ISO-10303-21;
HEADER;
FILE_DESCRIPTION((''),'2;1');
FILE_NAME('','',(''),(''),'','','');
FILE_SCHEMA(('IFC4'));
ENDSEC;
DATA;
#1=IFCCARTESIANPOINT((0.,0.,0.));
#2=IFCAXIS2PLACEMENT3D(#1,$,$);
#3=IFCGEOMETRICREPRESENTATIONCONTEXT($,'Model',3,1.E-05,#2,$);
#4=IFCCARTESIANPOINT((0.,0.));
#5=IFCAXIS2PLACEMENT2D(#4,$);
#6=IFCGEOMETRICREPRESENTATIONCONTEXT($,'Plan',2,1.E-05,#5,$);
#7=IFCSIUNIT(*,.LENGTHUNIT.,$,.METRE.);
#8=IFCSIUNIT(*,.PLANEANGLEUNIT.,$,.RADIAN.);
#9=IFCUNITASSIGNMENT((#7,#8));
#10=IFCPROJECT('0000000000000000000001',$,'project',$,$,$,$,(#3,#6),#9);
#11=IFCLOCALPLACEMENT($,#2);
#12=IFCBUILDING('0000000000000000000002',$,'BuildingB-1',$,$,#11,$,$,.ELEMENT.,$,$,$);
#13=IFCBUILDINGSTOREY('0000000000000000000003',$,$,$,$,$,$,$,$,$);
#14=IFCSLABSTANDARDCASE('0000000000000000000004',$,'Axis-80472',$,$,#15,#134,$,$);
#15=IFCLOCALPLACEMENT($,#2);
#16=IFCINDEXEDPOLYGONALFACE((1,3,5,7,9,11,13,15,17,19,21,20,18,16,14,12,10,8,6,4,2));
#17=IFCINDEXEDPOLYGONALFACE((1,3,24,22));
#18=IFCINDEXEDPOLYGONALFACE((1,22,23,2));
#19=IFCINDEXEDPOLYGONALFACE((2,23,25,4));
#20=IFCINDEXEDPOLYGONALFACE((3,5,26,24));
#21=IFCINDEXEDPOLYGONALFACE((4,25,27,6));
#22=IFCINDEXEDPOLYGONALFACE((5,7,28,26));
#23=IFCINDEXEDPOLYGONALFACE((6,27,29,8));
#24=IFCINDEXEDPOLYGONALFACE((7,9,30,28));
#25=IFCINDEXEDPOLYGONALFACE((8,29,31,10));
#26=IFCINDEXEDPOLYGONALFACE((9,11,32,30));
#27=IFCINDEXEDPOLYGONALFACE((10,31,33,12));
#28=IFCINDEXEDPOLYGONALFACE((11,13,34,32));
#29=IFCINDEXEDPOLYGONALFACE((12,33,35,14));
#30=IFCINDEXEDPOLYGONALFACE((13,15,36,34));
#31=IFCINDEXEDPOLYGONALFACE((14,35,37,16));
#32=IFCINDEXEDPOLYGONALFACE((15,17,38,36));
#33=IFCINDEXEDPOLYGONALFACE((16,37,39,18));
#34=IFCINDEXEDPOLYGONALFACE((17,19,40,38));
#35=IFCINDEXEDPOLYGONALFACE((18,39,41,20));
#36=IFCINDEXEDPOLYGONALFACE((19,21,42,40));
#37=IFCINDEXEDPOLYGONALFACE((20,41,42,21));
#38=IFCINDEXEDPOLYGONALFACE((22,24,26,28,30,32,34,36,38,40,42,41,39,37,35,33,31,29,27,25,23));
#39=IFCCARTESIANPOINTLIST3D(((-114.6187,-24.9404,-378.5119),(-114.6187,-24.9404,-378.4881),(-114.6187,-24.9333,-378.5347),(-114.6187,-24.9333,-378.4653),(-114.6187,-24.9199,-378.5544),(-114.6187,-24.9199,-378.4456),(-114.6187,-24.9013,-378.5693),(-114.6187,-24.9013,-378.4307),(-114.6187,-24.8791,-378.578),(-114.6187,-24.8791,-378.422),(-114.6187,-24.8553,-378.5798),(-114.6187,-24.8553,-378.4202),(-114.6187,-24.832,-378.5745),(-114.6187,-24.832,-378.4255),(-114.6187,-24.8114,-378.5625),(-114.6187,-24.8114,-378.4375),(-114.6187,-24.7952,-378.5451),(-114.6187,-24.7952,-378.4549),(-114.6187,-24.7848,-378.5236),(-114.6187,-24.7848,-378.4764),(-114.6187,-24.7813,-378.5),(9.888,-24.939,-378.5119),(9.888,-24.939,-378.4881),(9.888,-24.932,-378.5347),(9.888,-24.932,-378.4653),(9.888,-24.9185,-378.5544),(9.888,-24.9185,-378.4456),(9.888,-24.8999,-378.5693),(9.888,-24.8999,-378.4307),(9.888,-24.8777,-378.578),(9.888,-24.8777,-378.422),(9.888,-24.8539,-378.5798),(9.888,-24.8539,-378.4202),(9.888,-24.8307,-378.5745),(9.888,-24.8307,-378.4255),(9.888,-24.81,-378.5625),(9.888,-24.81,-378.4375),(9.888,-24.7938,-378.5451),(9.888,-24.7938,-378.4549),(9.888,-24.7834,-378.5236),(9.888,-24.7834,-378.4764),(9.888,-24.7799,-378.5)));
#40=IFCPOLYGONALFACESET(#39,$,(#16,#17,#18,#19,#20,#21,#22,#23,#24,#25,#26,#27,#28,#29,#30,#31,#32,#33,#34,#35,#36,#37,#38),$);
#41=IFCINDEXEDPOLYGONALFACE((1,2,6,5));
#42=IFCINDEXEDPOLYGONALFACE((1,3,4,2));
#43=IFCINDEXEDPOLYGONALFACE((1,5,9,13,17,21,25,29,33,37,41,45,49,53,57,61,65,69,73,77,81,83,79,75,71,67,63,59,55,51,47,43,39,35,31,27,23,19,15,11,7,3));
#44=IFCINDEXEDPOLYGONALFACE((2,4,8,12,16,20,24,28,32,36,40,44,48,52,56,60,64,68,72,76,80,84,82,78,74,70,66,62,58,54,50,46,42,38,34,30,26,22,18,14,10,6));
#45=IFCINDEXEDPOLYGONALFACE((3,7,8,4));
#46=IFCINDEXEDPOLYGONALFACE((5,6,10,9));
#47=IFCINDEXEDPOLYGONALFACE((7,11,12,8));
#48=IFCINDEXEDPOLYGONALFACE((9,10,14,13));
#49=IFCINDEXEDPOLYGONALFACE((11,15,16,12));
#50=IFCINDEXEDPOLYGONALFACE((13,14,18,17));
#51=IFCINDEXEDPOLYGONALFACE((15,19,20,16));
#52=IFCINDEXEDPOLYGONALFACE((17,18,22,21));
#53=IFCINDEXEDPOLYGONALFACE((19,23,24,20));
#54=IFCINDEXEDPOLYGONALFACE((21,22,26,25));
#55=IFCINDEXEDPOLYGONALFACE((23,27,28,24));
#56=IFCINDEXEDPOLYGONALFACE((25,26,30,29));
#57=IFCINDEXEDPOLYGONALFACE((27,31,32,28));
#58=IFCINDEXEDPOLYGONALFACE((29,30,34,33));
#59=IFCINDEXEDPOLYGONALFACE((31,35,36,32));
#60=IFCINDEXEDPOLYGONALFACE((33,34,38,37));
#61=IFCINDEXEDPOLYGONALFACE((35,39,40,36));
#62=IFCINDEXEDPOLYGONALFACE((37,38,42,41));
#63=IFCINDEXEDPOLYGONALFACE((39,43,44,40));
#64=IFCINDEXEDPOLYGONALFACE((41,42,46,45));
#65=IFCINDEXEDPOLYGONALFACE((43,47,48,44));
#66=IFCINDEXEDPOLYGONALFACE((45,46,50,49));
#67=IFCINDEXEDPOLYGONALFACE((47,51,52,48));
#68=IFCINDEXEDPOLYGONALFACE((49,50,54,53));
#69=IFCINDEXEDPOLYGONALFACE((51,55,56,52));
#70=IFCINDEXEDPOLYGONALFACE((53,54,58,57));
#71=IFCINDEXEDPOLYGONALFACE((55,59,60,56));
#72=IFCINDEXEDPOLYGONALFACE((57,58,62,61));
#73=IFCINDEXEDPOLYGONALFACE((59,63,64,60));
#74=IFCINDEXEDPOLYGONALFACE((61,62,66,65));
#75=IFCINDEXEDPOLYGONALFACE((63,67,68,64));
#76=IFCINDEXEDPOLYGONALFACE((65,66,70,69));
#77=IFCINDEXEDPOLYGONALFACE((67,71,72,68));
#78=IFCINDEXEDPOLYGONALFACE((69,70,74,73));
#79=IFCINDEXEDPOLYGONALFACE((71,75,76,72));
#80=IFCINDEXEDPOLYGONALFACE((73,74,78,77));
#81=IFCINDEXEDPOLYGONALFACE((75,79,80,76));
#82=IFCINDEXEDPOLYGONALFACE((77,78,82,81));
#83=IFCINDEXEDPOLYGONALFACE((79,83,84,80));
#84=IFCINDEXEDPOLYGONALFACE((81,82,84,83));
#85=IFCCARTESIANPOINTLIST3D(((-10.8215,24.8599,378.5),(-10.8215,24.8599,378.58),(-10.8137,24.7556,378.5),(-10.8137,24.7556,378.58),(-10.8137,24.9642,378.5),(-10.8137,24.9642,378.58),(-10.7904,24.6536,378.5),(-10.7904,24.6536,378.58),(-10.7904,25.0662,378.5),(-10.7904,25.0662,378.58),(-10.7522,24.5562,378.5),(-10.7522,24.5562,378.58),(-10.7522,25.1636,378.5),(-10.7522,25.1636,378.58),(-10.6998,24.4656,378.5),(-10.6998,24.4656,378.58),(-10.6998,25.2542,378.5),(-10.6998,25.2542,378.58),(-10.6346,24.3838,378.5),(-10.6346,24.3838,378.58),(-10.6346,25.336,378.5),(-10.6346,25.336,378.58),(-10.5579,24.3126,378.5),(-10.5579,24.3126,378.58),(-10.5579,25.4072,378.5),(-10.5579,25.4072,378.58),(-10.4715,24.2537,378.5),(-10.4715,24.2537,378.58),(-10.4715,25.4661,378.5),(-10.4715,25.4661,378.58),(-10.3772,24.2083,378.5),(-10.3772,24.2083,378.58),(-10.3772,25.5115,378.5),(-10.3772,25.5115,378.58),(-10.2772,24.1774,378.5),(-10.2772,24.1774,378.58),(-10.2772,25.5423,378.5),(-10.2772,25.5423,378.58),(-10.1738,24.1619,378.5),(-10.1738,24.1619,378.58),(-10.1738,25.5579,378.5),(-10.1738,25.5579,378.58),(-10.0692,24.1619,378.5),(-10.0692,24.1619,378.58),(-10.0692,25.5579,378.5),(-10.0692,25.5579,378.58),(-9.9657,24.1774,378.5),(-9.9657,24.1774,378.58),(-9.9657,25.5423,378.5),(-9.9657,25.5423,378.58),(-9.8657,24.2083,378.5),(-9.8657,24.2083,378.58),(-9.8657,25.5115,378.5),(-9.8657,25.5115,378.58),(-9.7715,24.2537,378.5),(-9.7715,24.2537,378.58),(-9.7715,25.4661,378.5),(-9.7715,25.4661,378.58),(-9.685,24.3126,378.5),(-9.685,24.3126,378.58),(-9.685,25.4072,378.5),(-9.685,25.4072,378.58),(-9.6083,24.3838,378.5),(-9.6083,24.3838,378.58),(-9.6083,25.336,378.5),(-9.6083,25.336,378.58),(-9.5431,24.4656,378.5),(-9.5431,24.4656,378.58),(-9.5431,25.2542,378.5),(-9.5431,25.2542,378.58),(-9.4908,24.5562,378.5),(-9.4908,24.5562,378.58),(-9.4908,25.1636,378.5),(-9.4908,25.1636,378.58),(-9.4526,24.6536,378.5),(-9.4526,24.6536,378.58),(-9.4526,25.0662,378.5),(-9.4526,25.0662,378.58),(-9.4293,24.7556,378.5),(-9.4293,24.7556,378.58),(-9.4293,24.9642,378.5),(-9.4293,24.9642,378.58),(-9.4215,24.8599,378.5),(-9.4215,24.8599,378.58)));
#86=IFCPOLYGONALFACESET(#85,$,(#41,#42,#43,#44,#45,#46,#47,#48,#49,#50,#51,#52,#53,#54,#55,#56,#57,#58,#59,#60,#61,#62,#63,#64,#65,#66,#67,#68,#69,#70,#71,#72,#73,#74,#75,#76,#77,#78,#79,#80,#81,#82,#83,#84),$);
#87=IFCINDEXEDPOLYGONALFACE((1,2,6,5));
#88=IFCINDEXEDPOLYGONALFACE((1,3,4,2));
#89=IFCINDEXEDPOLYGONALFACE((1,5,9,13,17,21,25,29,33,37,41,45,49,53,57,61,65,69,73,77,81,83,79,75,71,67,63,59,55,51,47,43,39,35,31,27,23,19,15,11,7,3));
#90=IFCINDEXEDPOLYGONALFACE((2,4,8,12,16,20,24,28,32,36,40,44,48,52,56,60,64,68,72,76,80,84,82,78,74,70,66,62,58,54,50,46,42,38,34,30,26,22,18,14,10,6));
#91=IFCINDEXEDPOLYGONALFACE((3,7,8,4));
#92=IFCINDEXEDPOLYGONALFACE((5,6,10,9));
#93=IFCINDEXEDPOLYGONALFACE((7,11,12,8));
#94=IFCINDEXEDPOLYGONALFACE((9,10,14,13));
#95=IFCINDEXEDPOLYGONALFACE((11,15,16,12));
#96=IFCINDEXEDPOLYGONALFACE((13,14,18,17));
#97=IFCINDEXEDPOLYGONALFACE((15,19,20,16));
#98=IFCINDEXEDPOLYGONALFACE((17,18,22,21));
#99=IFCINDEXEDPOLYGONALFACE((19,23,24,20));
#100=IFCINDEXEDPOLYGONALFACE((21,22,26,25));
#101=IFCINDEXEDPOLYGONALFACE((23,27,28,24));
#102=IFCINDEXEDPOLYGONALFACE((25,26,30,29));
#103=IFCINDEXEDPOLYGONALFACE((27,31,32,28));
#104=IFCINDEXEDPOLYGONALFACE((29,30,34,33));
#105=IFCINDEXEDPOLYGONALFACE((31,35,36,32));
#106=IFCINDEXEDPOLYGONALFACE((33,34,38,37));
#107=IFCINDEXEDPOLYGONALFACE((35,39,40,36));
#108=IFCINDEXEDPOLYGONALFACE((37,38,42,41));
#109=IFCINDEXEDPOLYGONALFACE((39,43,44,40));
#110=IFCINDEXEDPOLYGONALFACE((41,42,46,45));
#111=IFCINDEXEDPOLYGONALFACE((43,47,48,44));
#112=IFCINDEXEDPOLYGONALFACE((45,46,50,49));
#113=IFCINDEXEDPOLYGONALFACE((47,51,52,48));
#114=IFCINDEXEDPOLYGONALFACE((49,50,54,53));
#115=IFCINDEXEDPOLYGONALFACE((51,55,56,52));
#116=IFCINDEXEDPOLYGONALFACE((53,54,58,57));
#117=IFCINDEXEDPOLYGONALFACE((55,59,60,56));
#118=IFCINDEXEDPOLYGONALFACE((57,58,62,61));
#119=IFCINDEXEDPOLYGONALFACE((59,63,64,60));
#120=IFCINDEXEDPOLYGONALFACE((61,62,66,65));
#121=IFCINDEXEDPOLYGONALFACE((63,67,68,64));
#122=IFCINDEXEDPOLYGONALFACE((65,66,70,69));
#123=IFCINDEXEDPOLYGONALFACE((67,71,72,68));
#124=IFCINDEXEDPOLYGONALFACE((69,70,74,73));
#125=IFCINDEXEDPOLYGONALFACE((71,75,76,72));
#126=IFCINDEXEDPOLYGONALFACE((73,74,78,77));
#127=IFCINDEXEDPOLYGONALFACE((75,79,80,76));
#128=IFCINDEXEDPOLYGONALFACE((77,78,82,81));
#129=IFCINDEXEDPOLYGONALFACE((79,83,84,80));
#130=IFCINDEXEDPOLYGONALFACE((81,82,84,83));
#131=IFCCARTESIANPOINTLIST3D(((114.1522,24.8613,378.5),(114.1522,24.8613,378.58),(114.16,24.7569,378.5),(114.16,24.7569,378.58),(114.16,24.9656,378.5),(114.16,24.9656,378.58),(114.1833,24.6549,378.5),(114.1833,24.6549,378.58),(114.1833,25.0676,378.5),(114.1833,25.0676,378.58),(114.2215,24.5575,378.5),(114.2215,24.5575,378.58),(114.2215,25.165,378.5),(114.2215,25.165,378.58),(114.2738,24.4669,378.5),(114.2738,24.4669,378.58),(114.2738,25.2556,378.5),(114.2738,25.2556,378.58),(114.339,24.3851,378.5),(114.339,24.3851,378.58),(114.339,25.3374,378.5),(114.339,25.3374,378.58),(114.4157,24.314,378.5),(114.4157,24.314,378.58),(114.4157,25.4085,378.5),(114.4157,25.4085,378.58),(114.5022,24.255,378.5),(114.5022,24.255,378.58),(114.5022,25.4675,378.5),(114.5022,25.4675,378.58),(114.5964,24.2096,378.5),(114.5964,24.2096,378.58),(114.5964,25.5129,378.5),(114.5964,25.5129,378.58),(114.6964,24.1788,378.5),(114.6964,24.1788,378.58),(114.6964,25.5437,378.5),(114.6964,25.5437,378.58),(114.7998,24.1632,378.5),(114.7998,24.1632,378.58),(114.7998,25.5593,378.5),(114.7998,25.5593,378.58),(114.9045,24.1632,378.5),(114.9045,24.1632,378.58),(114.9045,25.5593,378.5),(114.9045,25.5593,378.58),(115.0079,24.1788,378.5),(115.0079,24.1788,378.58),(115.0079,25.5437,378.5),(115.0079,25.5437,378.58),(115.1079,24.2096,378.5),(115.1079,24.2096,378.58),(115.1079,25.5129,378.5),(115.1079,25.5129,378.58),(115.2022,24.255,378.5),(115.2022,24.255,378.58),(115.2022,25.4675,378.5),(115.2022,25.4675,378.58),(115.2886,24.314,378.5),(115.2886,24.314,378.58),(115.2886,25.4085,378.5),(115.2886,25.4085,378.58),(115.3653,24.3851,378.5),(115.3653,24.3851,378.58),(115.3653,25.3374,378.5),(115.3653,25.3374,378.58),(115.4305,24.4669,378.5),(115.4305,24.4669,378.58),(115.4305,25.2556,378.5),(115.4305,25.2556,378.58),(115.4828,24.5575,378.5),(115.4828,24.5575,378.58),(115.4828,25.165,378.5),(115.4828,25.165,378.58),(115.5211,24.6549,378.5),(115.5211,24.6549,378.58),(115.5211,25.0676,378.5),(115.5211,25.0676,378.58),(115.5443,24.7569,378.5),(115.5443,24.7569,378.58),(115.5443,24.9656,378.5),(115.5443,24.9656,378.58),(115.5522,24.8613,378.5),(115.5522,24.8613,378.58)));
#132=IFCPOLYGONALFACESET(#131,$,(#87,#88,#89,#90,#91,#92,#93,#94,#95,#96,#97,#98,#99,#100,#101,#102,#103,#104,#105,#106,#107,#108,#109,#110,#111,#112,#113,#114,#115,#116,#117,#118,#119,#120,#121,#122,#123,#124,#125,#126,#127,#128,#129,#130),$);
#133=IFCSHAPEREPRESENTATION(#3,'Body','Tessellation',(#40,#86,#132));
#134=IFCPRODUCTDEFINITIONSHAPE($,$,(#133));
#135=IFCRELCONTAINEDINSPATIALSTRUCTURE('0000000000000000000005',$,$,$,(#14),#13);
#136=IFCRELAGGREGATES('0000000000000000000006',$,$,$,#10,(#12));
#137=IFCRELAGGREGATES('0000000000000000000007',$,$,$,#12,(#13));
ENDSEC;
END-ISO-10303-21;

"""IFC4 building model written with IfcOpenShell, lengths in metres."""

from ifc_helpers import new_model, entity, si_unit, frame, origin, origin_2d, place, context, project, spatial, circle, extrude, element, save


model = new_model("IFC4")

# Units and contexts
model_context = context("Model", 3, precision=1e-05, world=origin())
plan_context = context("Plan", 2, precision=1e-05, world=origin_2d())
ifc_project = project(units=[si_unit("LENGTHUNIT", "METRE"), si_unit("PLANEANGLEUNIT", "RADIAN")], contexts=[model_context, plan_context])

# Building, storey
building_placement = place(None, origin())
building = spatial("IfcBuilding", under=ifc_project, at=building_placement, Name="BuildingB-1", CompositionType="ELEMENT")
storey = spatial("IfcBuildingStorey", under=building)

# Slab
element("IfcSlabStandardCase", 1, inside=storey, Name="Axis-80472", context=model_context, shape_type="AdvancedSweptSolid", body=[
    entity("IfcSurfaceCurveSweptAreaSolid", entity("IfcCircleProfileDef", "AREA", None, None, 0.08), None, entity("IfcPolyline", [entity("IfcCartesianPoint", [-9.888, 24.8599, 378.5]), entity("IfcCartesianPoint", [114.6187, 24.8613, 378.5])]), None, None, entity("IfcPlane", entity("IfcAxis2Placement3D", entity("IfcCartesianPoint", [-9.888, 24.8599, 378.5]), entity("IfcDirection", [0.0, 0.0, 1.0]), entity("IfcDirection", [1.0, 0.0, 0.0])))),
    extrude(circle(Radius=0.7), frame((-10.1215, 24.8599, 378.5)), (0.0, 0.0, 1.0), 0.08),
    extrude(circle(Radius=0.7), frame((114.8522, 24.8613, 378.5)), (0.0, 0.0, 1.0), 0.08),
])

save(model, "model.ifc")
